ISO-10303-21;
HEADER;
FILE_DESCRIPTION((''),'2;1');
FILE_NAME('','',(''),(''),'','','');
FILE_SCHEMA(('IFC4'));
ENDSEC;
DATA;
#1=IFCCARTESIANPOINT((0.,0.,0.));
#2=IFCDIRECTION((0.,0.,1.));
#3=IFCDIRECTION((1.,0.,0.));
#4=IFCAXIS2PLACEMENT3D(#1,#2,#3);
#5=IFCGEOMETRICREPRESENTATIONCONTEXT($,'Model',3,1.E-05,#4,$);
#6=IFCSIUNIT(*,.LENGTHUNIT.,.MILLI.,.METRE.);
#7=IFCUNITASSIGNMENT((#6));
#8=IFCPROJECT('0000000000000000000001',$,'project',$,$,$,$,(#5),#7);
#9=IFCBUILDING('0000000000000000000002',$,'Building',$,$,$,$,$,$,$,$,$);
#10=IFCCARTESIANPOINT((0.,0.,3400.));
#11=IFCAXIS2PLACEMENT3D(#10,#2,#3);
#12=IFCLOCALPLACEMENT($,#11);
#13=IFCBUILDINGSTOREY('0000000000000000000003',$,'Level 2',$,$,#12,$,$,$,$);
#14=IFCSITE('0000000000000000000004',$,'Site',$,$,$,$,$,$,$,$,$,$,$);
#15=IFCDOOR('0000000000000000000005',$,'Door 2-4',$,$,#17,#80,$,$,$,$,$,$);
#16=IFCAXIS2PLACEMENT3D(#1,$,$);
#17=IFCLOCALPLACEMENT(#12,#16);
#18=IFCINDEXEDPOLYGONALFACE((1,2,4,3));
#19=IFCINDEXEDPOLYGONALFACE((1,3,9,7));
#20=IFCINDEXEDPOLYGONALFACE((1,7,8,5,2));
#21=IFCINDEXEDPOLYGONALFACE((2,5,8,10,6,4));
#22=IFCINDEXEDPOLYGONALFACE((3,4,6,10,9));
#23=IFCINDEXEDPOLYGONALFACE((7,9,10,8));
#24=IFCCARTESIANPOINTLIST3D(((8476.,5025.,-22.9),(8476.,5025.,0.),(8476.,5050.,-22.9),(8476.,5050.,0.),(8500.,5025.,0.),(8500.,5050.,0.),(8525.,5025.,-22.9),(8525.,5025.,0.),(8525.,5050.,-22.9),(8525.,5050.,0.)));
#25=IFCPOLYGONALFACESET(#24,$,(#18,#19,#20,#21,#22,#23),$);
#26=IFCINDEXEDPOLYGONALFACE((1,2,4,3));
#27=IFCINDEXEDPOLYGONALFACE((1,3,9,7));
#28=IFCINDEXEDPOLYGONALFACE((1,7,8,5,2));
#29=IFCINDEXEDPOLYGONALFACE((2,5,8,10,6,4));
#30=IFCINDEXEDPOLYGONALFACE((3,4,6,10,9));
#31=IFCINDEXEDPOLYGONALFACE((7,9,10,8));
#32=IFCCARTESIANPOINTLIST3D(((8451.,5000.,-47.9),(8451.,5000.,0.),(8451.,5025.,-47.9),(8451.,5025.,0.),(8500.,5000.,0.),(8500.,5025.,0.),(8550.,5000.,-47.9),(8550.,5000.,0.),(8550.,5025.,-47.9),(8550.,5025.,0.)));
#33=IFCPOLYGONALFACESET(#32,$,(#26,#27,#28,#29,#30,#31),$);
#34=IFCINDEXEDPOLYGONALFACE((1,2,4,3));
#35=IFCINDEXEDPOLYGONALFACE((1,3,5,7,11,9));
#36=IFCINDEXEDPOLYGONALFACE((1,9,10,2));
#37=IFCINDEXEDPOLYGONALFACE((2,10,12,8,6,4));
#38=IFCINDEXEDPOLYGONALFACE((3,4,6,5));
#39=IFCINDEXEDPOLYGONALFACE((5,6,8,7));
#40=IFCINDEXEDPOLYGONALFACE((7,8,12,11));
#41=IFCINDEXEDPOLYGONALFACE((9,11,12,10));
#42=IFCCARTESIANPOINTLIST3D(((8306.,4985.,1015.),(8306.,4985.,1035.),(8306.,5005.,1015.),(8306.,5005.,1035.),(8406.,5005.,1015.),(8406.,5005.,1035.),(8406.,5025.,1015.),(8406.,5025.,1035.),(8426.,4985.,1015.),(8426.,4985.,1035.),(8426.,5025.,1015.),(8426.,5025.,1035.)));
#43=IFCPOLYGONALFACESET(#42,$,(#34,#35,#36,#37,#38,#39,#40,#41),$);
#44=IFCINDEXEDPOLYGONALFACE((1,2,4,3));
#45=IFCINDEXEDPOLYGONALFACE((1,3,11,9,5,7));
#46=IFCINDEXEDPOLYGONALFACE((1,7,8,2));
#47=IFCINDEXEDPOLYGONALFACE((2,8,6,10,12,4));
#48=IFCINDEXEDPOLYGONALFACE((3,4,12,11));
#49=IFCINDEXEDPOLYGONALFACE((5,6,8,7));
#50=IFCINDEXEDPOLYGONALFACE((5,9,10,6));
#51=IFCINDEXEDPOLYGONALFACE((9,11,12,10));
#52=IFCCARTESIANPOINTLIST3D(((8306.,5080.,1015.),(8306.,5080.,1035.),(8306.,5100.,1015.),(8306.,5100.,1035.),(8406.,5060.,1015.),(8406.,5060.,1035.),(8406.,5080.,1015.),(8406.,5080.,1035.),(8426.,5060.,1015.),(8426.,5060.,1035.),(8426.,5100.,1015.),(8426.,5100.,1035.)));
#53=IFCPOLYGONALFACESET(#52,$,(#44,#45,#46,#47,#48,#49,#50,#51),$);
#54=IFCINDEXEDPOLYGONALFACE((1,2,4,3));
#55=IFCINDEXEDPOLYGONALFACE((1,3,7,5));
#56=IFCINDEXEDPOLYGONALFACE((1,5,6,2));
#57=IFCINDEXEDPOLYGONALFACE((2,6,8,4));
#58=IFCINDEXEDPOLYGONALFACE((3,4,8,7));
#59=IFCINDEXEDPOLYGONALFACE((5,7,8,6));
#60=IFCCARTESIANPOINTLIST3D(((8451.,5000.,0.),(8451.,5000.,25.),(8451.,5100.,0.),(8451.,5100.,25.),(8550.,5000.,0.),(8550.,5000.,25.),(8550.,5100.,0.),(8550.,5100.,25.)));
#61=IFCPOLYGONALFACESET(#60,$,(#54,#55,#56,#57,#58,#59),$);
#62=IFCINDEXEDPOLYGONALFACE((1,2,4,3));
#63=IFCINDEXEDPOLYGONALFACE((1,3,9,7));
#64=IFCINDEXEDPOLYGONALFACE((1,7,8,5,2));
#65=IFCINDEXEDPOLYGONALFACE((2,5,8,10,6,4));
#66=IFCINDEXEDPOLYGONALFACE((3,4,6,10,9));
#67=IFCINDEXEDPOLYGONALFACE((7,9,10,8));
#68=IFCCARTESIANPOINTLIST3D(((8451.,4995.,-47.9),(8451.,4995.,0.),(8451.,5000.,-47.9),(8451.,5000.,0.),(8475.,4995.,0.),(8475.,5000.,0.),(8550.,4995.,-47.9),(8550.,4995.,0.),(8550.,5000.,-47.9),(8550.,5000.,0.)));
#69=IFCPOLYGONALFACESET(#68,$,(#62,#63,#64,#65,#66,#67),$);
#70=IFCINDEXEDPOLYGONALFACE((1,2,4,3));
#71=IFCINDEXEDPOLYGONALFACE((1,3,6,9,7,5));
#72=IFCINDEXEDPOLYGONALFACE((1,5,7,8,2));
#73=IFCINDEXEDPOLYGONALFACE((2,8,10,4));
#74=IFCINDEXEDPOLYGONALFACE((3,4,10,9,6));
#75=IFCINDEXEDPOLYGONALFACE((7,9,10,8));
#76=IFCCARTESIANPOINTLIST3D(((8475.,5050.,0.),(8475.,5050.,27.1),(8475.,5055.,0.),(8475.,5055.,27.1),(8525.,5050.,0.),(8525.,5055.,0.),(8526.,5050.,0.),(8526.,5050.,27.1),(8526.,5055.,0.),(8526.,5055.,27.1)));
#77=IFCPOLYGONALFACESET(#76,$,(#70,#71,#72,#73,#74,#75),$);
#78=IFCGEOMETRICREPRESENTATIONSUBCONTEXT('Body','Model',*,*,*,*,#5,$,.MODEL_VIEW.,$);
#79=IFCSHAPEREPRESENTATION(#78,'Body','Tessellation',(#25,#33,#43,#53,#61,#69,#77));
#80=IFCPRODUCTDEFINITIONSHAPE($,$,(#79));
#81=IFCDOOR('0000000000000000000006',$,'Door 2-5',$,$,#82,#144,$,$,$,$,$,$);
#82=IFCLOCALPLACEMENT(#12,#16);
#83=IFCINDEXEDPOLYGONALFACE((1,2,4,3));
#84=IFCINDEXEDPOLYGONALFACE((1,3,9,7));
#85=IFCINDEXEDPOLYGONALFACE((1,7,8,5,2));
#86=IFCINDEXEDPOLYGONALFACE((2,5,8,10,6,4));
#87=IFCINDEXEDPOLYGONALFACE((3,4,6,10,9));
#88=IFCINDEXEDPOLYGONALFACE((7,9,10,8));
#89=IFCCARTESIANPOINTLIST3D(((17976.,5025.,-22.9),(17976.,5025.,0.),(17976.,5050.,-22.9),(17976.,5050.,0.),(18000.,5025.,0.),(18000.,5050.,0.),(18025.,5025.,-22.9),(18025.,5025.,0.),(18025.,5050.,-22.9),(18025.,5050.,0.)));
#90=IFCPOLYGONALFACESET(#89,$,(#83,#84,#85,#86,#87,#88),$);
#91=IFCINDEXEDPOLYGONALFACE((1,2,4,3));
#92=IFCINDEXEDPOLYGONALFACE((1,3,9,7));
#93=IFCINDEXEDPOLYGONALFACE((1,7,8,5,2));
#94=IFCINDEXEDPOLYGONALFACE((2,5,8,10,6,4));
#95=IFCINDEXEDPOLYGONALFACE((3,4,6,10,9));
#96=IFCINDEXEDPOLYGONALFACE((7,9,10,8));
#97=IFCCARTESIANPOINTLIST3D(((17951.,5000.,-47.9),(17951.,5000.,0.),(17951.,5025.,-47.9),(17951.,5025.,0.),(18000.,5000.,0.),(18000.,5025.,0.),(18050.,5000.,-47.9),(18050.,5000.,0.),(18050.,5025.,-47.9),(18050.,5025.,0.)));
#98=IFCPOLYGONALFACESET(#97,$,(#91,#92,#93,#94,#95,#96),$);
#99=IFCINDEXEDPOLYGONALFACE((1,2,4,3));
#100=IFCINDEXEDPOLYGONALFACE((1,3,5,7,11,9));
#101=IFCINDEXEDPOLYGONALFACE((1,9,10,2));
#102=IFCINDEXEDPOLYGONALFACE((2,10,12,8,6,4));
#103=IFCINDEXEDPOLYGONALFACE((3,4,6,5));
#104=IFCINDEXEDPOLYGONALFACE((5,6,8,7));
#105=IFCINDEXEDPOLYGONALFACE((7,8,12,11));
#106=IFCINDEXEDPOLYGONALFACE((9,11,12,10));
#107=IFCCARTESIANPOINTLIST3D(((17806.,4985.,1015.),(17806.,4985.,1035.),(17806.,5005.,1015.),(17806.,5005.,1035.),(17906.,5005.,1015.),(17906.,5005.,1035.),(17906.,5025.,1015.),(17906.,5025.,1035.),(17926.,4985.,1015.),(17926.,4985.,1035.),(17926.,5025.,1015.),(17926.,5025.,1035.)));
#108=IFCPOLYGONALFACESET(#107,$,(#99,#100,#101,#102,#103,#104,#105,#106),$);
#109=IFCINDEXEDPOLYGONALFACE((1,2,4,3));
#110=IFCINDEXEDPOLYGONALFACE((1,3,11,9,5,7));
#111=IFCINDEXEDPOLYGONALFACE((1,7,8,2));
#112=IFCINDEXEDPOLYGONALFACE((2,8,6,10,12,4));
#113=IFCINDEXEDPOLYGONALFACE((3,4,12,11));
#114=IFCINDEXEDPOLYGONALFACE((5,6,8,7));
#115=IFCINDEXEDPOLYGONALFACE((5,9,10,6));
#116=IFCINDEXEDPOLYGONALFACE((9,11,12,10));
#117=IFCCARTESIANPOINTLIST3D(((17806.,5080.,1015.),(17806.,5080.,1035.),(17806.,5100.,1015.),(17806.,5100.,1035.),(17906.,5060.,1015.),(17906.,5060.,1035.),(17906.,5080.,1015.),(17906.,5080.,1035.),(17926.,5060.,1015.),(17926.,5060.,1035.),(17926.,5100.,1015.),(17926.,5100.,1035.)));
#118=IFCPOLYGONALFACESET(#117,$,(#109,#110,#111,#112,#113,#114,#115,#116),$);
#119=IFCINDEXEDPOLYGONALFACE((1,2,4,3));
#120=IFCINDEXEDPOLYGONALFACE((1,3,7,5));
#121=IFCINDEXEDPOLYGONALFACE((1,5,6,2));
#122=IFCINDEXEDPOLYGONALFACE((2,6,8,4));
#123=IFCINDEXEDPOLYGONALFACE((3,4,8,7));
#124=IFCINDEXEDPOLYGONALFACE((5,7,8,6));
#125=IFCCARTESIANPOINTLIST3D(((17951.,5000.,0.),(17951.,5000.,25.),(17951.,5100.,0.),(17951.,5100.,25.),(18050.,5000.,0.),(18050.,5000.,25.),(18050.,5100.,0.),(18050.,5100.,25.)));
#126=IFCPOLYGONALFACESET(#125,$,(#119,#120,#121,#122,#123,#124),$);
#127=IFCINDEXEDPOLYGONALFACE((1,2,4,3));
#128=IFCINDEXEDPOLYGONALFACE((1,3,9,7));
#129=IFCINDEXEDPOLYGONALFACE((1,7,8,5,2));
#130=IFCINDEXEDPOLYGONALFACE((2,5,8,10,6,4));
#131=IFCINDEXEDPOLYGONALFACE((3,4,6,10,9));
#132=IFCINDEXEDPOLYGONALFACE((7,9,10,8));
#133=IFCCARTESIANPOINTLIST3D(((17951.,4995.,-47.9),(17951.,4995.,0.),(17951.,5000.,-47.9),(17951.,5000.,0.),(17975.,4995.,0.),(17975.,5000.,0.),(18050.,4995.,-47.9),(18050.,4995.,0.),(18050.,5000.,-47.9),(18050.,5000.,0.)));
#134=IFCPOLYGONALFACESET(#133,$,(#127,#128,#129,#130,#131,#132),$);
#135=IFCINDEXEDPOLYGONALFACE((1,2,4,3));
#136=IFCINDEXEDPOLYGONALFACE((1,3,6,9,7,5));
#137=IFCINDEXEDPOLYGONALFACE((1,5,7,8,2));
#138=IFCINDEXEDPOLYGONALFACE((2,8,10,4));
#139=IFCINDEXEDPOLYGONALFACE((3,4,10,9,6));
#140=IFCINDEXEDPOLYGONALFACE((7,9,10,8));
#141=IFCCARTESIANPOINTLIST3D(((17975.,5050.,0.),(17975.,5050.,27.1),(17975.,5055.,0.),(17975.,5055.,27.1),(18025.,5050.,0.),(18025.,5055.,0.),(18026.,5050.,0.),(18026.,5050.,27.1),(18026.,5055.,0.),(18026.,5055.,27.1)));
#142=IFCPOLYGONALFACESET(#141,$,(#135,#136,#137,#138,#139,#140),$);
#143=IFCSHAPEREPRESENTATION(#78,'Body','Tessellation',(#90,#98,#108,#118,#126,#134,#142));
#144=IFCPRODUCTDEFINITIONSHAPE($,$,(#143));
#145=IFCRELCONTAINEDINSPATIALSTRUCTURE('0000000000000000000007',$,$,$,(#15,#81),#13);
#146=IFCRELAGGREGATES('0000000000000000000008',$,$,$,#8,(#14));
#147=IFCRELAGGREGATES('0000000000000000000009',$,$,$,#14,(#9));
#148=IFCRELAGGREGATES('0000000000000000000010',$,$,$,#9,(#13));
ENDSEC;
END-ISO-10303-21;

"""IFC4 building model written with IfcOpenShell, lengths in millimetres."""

from ifc_helpers import new_model, si_unit, frame, origin_with_axes, place, context, subcontext, project, spatial, line, indexed_curve, outline, extrude, element, save


model = new_model("IFC4")

# Units and contexts
model_context = context("Model", 3, precision=1e-05, world=origin_with_axes())
body_context = subcontext(model_context, "Body", "Model", "MODEL_VIEW")
ifc_project = project(units=[si_unit("LENGTHUNIT", "METRE", prefix="MILLI")], contexts=[model_context])

# Site, building, storey
site = spatial("IfcSite", under=ifc_project, Name="Site")
building = spatial("IfcBuilding", under=site, Name="Building")
storey_placement = place(None, frame((0.0, 0.0, 3400.0), z_axis=(0.0, 0.0, 1.0), x_axis=(1.0, 0.0, 0.0)))
storey = spatial("IfcBuildingStorey", under=building, at=storey_placement, Name="Level 2")

# Doors
door_1_placement = place(storey_placement, frame((8500.0, 5000.0, 0.0), z_axis=(0.0, 0.0, 1.0), x_axis=(1.0, 0.0, 0.0)))
element("IfcDoor", 1, at=door_1_placement, inside=storey, Name="Door 2-4", context=body_context, shape_type="SweptSolid", body=[
    extrude(outline(indexed_curve([(0.0, 0.0), (0.0, 2.1), (1.0, 2.1), (1.0, 0.0), (-24.0, 0.0), (-24.0, -22.9), (25.0, -22.9), (25.0, 0.0)], segments=[line(1, 2, 3, 4, 5, 6, 7, 8, 1)])), frame((0.0, 25.0, 0.0), z_axis=(0.0, -1.0, 0.0), x_axis=(1.0, 0.0, 0.0)), (0.0, 0.0, -1.0), 25.0),
    extrude(outline(indexed_curve([(0.0, 0.0), (0.0, 2.1), (1.0, 2.1), (1.0, 0.0), (-49.0, 0.0), (-49.0, -47.9), (50.0, -47.9), (50.0, 0.0)], segments=[line(1, 2, 3, 4, 5, 6, 7, 8, 1)])), frame((0.0, 0.0, 0.0), z_axis=(0.0, -1.0, 0.0), x_axis=(1.0, 0.0, 0.0)), (0.0, 0.0, -1.0), 25.0),
    extrude(outline(indexed_curve([(0.0, 0.0), (-49.0, 0.0), (-49.0, 35.0), (0.0, 35.0)], segments=[line(1, 2, 3, 4, 1)])), frame((25.0, 25.0, 25.0), z_axis=(0.0, 0.0, 1.0), x_axis=(1.0, 0.0, 0.0)), (0.0, 0.0, 1.0), -47.9),
    extrude(outline(indexed_curve([(0.0, 0.0), (0.0, -40.0), (-120.0, -40.0), (-120.0, -20.0), (-20.0, -20.0), (-20.0, 0.0)], segments=[line(1, 2, 3, 4, 5, 6, 1)])), frame((-74.0, 25.0, 1015.0), z_axis=(0.0, 0.0, 1.0), x_axis=(1.0, 0.0, 0.0)), (0.0, 0.0, 1.0), 20.0),
    extrude(outline(indexed_curve([(0.0, 0.0), (0.0, 40.0), (-120.0, 40.0), (-120.0, 20.0), (-20.0, 20.0), (-20.0, 0.0)], segments=[line(1, 2, 3, 4, 5, 6, 1)])), frame((-74.0, 60.0, 1015.0), z_axis=(0.0, 0.0, 1.0), x_axis=(1.0, 0.0, 0.0)), (0.0, 0.0, 1.0), 20.0),
    extrude(outline(indexed_curve([(0.0, 0.0), (-99.0, 0.0), (-99.0, 100.0), (0.0, 100.0)], segments=[line(1, 2, 3, 4, 1)])), frame((50.0, 0.0, 0.0), z_axis=(0.0, 0.0, 1.0), x_axis=(1.0, 0.0, 0.0)), (0.0, 0.0, 1.0), 25.0),
    extrude(outline(indexed_curve([(0.0, 0.0), (0.0, 27.1), (51.0, 27.1), (51.0, 0.0), (-24.0, 0.0), (-24.0, -47.9), (75.0, -47.9), (75.0, 0.0)], segments=[line(1, 2, 3, 4, 5, 6, 7, 8, 1)])), frame((-25.0, -5.0, 0.0), z_axis=(0.0, -1.0, 0.0), x_axis=(1.0, 0.0, 0.0)), (0.0, 0.0, -1.0), 5.0),
    extrude(outline(indexed_curve([(0.0, 0.0), (0.0, 27.1), (51.0, 27.1), (51.0, 0.0), (1.0, 0.0), (1.0, -22.9), (50.0, -22.9), (50.0, 0.0)], segments=[line(1, 2, 3, 4, 5, 6, 7, 8, 1)])), frame((-25.0, 50.0, 0.0), z_axis=(0.0, -1.0, 0.0), x_axis=(1.0, 0.0, 0.0)), (0.0, 0.0, -1.0), 5.0),
])
door_2_placement = place(storey_placement, frame((18000.0, 5000.0, 0.0), z_axis=(0.0, 0.0, 1.0), x_axis=(1.0, 0.0, 0.0)))
element("IfcDoor", 2, at=door_2_placement, inside=storey, Name="Door 2-5", context=body_context, shape_type="SweptSolid", body=[
    extrude(outline(indexed_curve([(0.0, 0.0), (0.0, 2.1), (1.0, 2.1), (1.0, 0.0), (-24.0, 0.0), (-24.0, -22.9), (25.0, -22.9), (25.0, 0.0)], segments=[line(1, 2, 3, 4, 5, 6, 7, 8, 1)])), frame((0.0, 25.0, 0.0), z_axis=(0.0, -1.0, 0.0), x_axis=(1.0, 0.0, 0.0)), (0.0, 0.0, -1.0), 25.0),
    extrude(outline(indexed_curve([(0.0, 0.0), (0.0, 2.1), (1.0, 2.1), (1.0, 0.0), (-49.0, 0.0), (-49.0, -47.9), (50.0, -47.9), (50.0, 0.0)], segments=[line(1, 2, 3, 4, 5, 6, 7, 8, 1)])), frame((0.0, 0.0, 0.0), z_axis=(0.0, -1.0, 0.0), x_axis=(1.0, 0.0, 0.0)), (0.0, 0.0, -1.0), 25.0),
    extrude(outline(indexed_curve([(0.0, 0.0), (-49.0, 0.0), (-49.0, 35.0), (0.0, 35.0)], segments=[line(1, 2, 3, 4, 1)])), frame((25.0, 25.0, 25.0), z_axis=(0.0, 0.0, 1.0), x_axis=(1.0, 0.0, 0.0)), (0.0, 0.0, 1.0), -47.9),
    extrude(outline(indexed_curve([(0.0, 0.0), (0.0, -40.0), (-120.0, -40.0), (-120.0, -20.0), (-20.0, -20.0), (-20.0, 0.0)], segments=[line(1, 2, 3, 4, 5, 6, 1)])), frame((-74.0, 25.0, 1015.0), z_axis=(0.0, 0.0, 1.0), x_axis=(1.0, 0.0, 0.0)), (0.0, 0.0, 1.0), 20.0),
    extrude(outline(indexed_curve([(0.0, 0.0), (0.0, 40.0), (-120.0, 40.0), (-120.0, 20.0), (-20.0, 20.0), (-20.0, 0.0)], segments=[line(1, 2, 3, 4, 5, 6, 1)])), frame((-74.0, 60.0, 1015.0), z_axis=(0.0, 0.0, 1.0), x_axis=(1.0, 0.0, 0.0)), (0.0, 0.0, 1.0), 20.0),
    extrude(outline(indexed_curve([(0.0, 0.0), (-99.0, 0.0), (-99.0, 100.0), (0.0, 100.0)], segments=[line(1, 2, 3, 4, 1)])), frame((50.0, 0.0, 0.0), z_axis=(0.0, 0.0, 1.0), x_axis=(1.0, 0.0, 0.0)), (0.0, 0.0, 1.0), 25.0),
    extrude(outline(indexed_curve([(0.0, 0.0), (0.0, 27.1), (51.0, 27.1), (51.0, 0.0), (-24.0, 0.0), (-24.0, -47.9), (75.0, -47.9), (75.0, 0.0)], segments=[line(1, 2, 3, 4, 5, 6, 7, 8, 1)])), frame((-25.0, -5.0, 0.0), z_axis=(0.0, -1.0, 0.0), x_axis=(1.0, 0.0, 0.0)), (0.0, 0.0, -1.0), 5.0),
    extrude(outline(indexed_curve([(0.0, 0.0), (0.0, 27.1), (51.0, 27.1), (51.0, 0.0), (1.0, 0.0), (1.0, -22.9), (50.0, -22.9), (50.0, 0.0)], segments=[line(1, 2, 3, 4, 5, 6, 7, 8, 1)])), frame((-25.0, 50.0, 0.0), z_axis=(0.0, -1.0, 0.0), x_axis=(1.0, 0.0, 0.0)), (0.0, 0.0, -1.0), 5.0),
])

save(model, "model.ifc")
